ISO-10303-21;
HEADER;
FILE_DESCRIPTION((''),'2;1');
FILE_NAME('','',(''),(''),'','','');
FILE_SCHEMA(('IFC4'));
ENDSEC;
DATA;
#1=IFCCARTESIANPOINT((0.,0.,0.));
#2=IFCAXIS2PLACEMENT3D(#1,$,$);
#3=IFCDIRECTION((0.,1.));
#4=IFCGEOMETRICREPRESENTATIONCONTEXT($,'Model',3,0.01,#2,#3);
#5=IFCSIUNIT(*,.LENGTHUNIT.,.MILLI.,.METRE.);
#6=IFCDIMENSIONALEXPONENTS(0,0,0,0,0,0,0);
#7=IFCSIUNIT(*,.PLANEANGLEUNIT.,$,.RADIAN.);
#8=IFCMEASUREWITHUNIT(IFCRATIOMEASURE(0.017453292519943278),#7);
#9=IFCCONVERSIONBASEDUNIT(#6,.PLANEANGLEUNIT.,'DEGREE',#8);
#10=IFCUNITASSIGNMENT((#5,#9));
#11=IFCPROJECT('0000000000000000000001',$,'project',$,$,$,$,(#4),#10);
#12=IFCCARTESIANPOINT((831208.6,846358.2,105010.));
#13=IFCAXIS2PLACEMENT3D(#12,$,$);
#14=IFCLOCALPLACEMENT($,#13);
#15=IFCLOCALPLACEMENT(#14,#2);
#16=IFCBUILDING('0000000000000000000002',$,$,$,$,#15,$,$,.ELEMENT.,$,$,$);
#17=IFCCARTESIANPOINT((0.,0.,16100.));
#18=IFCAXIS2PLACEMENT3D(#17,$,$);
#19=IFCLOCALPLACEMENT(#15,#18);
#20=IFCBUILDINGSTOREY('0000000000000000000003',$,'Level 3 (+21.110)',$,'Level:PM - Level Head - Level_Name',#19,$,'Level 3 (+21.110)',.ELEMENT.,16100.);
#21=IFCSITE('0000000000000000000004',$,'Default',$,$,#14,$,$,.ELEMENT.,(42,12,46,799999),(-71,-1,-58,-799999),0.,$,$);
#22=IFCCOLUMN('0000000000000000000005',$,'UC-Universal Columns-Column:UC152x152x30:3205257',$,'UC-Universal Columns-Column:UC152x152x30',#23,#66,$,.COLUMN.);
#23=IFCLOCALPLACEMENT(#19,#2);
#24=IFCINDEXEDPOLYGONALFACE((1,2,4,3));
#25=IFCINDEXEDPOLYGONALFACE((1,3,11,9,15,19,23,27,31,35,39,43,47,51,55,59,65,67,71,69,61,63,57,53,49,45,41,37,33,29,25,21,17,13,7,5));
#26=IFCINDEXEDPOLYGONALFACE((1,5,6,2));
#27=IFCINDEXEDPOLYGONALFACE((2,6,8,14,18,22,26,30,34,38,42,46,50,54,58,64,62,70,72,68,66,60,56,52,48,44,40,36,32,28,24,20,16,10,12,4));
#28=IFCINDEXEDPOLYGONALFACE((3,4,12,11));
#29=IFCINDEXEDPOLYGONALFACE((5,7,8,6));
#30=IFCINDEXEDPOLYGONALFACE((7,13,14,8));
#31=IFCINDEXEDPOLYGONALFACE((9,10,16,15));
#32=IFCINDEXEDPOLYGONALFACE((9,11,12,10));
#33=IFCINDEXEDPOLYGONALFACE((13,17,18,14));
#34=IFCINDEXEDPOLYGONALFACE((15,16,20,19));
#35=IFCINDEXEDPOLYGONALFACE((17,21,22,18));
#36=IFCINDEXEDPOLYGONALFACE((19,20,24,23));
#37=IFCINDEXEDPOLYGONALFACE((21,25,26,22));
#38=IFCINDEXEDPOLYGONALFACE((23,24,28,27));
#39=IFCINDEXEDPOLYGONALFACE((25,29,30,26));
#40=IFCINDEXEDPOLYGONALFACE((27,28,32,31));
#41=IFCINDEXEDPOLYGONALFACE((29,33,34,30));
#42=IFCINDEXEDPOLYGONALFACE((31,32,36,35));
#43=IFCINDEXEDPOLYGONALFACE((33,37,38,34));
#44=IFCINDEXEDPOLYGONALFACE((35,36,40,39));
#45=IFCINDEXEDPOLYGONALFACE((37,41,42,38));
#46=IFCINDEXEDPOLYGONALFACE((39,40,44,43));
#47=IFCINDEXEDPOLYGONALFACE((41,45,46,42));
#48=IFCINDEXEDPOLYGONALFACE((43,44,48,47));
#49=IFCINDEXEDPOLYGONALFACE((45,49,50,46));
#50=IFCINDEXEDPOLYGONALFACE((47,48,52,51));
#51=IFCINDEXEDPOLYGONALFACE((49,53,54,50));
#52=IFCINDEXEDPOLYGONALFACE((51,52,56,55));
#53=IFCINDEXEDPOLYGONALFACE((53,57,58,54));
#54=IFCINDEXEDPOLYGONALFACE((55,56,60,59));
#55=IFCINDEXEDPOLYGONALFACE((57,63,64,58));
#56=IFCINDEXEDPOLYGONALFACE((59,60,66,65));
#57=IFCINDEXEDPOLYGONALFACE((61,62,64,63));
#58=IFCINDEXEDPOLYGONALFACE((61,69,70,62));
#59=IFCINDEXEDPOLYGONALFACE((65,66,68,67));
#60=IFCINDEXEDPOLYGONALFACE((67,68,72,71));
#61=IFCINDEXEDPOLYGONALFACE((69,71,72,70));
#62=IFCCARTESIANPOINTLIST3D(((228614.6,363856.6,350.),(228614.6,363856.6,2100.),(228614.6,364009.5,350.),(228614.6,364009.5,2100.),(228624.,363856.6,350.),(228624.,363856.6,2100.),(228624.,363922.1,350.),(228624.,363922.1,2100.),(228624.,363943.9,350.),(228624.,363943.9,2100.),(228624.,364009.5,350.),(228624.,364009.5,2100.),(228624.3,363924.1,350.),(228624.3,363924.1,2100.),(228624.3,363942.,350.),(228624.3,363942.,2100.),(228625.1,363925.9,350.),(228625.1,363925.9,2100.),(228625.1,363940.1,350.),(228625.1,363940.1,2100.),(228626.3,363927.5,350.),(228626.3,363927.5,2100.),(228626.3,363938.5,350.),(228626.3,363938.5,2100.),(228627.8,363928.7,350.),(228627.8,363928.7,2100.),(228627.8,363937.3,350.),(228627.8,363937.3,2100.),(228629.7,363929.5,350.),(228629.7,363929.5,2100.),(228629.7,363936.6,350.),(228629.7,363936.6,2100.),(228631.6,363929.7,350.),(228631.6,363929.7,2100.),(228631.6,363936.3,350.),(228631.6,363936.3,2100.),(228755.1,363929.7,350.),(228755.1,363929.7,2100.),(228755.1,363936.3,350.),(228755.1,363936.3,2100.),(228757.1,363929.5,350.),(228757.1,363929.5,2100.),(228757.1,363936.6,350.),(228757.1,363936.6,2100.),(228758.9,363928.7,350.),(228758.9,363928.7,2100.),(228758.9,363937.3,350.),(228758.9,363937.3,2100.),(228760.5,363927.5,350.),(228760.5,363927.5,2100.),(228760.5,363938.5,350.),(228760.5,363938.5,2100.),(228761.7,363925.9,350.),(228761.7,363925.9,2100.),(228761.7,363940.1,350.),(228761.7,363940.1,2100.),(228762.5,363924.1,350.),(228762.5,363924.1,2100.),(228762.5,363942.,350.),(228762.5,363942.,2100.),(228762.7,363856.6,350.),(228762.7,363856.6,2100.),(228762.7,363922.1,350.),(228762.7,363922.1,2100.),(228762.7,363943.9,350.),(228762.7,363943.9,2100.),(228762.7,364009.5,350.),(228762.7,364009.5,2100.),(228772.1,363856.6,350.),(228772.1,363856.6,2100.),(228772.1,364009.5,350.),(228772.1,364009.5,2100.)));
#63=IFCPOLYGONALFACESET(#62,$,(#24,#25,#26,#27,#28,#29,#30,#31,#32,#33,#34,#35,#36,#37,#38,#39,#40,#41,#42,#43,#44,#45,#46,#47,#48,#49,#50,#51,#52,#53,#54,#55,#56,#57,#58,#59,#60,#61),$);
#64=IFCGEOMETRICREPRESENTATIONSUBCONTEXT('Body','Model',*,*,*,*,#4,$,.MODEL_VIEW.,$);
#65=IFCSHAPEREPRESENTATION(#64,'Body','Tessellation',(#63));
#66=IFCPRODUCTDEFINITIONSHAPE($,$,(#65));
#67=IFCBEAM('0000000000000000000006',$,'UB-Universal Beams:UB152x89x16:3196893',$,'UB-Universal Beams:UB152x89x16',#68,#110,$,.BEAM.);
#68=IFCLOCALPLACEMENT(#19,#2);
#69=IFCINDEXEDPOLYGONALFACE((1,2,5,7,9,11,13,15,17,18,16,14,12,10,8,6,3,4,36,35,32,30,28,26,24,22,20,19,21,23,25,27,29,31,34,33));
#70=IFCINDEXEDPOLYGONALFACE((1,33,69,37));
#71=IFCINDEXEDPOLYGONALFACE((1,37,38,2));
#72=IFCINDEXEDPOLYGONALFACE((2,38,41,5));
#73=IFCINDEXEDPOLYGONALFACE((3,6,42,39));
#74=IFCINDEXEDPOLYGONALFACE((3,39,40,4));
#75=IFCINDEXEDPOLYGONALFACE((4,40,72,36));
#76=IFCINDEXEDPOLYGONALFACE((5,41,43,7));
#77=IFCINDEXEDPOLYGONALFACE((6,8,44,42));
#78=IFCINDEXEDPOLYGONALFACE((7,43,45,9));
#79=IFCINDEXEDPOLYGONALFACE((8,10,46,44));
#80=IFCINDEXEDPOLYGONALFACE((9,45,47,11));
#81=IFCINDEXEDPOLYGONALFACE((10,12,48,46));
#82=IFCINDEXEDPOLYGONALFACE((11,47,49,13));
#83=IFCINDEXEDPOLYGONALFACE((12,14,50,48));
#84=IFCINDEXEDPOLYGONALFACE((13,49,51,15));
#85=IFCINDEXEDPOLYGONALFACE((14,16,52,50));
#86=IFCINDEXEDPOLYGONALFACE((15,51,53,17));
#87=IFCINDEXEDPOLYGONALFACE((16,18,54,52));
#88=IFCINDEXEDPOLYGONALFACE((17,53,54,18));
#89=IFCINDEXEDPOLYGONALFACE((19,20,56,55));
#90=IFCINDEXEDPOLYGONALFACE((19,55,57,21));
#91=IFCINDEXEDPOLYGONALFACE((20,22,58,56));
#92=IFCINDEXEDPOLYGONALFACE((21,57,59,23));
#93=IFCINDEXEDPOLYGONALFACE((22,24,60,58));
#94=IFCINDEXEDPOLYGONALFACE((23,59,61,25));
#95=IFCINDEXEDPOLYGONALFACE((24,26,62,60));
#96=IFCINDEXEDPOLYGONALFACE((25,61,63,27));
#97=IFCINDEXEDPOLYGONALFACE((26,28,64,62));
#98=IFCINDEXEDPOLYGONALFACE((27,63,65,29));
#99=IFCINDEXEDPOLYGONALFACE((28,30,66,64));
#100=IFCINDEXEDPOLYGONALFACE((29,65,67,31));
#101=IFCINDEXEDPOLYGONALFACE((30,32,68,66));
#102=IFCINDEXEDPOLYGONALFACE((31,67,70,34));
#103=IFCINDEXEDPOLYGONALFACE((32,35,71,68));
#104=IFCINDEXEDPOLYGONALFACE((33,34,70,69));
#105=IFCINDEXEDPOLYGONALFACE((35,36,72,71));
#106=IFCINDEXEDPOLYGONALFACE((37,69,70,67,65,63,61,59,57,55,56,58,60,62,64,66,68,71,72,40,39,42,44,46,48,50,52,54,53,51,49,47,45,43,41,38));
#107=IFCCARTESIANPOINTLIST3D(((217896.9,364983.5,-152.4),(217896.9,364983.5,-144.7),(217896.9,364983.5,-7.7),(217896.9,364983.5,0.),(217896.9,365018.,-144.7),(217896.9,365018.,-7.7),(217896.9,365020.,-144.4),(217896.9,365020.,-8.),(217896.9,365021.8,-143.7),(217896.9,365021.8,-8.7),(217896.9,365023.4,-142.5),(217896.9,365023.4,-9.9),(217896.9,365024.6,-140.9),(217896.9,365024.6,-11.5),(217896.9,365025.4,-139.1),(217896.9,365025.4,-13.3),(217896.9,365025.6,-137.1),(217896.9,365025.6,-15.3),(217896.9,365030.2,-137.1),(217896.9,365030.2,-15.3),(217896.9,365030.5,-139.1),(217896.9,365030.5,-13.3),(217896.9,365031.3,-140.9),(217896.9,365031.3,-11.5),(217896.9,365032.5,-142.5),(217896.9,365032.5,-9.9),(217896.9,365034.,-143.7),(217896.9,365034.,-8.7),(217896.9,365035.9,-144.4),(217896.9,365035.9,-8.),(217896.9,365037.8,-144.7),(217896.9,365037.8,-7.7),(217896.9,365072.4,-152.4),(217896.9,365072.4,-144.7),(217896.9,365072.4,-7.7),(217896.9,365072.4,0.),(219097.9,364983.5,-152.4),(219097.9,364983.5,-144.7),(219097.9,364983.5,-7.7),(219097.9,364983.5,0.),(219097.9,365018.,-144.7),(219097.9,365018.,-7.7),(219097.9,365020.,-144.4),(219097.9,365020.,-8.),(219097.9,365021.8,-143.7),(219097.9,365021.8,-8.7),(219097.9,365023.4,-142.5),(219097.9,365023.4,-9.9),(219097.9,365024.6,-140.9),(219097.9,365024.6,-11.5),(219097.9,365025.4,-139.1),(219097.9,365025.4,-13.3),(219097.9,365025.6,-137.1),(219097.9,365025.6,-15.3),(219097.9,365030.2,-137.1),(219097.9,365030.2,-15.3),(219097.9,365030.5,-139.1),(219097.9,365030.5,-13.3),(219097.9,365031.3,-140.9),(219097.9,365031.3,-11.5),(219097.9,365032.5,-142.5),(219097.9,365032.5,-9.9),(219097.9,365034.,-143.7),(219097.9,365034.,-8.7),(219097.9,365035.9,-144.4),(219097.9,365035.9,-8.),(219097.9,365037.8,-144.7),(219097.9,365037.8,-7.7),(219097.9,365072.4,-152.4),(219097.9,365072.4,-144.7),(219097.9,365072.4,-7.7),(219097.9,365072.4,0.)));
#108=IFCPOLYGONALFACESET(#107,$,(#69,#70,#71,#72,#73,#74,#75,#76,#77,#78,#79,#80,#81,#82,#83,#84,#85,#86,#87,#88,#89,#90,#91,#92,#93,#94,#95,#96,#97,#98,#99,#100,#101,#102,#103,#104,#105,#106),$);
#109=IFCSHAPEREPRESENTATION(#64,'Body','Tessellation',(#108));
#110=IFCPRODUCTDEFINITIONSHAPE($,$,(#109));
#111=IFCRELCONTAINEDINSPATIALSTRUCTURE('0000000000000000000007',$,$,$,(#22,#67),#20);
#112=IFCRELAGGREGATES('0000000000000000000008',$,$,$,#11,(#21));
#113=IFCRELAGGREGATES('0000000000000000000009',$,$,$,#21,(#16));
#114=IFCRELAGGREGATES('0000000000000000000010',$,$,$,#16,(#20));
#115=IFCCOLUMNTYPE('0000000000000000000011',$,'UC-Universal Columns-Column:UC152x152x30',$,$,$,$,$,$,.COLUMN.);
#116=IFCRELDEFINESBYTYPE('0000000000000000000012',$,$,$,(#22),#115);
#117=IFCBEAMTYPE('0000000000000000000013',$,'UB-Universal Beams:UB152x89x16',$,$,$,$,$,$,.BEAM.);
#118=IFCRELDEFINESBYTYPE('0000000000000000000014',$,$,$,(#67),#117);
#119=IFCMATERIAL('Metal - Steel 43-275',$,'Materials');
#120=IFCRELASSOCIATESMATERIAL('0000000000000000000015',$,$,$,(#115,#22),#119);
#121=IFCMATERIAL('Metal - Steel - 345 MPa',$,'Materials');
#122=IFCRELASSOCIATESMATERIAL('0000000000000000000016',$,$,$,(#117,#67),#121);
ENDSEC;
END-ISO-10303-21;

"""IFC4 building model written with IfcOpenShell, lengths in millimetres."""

from ifc_helpers import new_model, entity, si_unit, converted_unit, direction, frame, origin, place, context, subcontext, project, spatial, line, arc, indexed_curve, outline, extrude, source, transform, mapped, material, type_object, type_shapes, element, save


model = new_model("IFC4")

# Units and contexts
model_context = context("Model", 3, precision=0.01, world=origin(), true_north=direction((0.0, 1.0)))
body_context = subcontext(model_context, "Body", "Model", "MODEL_VIEW")
ifc_project = project(units=[si_unit("LENGTHUNIT", "METRE", prefix="MILLI"), converted_unit("PLANEANGLEUNIT", "DEGREE", entity("IfcRatioMeasure", 0.017453292519943278), si_unit("PLANEANGLEUNIT", "RADIAN"), dimensions=[0, 0, 0, 0, 0, 0, 0])], contexts=[model_context])

# Site, building, storey
site_placement = place(None, frame((831208.6, 846358.2, 105010.0)))
site = spatial("IfcSite", under=ifc_project, at=site_placement, Name="Default", CompositionType="ELEMENT", RefLatitude=(42, 12, 46, 799999), RefLongitude=(-71, -1, -58, -799999), RefElevation=0.0)
building_placement = place(site_placement, origin())
building = spatial("IfcBuilding", under=site, at=building_placement, CompositionType="ELEMENT")
storey_placement = place(building_placement, frame((0.0, 0.0, 16100.0)))
storey = spatial("IfcBuildingStorey", under=building, at=storey_placement, Name="Level 3 (+21.110)", ObjectType="Level:PM - Level Head - Level_Name", LongName="Level 3 (+21.110)", CompositionType="ELEMENT", Elevation=16100.0)

# Column
ifc_material_1 = material(Name="Metal - Steel 43-275", Category="Materials")
column_type = type_object("IfcColumnType", Name="UC-Universal Columns-Column:UC152x152x30", PredefinedType="COLUMN", material=ifc_material_1)
shared_shape_1 = source(origin(), body_context, "Body", "SweptSolid", [
    extrude(outline(indexed_curve([(69.3, -76.4), (78.7, -76.4), (78.7, 76.4), (69.3, 76.4), (69.3, 10.9), (67.1, 5.5), (61.7, 3.3), (-61.7, 3.3), (-67.1, 5.5), (-69.3, 10.9), (-69.3, 76.4), (-78.7, 76.4), (-78.7, -76.4), (-69.3, -76.4), (-69.3, -10.9), (-67.1, -5.5), (-61.7, -3.3), (61.7, -3.3), (67.1, -5.5), (69.3, -10.9)], segments=[line(1, 2, 3, 4, 5), arc(5, 6, 7), line(7, 8), arc(8, 9, 10), line(10, 11, 12, 13, 14, 15), arc(15, 16, 17), line(17, 18), arc(18, 19, 20), line(20, 1)], self_intersect=False)), frame((0.0, 0.0, 16450.0), z_axis=(0.0, 0.0, 1.0), x_axis=(0.0, -1.0, 0.0)), (0.0, 0.0, 1.0), 1750.0),
])
type_shapes(column_type, [shared_shape_1])
column_placement = place(storey_placement, frame((228693.4, 363933.0, -16100.0), z_axis=(0.0, 0.0, 1.0), x_axis=(0.0, 1.0, 0.0)))
element("IfcColumn", 1, at=column_placement, inside=storey, type_object=column_type, material=ifc_material_1, Name="UC-Universal Columns-Column:UC152x152x30:3205257", ObjectType="UC-Universal Columns-Column:UC152x152x30", PredefinedType="COLUMN", context=body_context, shape_type="MappedRepresentation", body=[
    mapped(shared_shape_1, transform((0.0, 0.0, 0.0), scale=1.0)),
])

# Beam
ifc_material_2 = material(Name="Metal - Steel - 345 MPa", Category="Materials")
beam_type = type_object("IfcBeamType", Name="UB-Universal Beams:UB152x89x16", PredefinedType="BEAM", material=ifc_material_2)
shared_shape_2 = source(origin(), body_context, "Body", "SweptSolid", [
    extrude(outline(indexed_curve([(-76.2, -44.5), (-68.5, -44.5), (-68.5, -9.9), (-66.3, -4.5), (-60.9, -2.3), (60.9, -2.3), (66.3, -4.5), (68.5, -9.9), (68.5, -44.5), (76.2, -44.5), (76.2, 44.5), (68.5, 44.5), (68.5, 9.9), (66.3, 4.5), (60.9, 2.3), (-60.9, 2.3), (-66.3, 4.5), (-68.5, 9.9), (-68.5, 44.4), (-76.2, 44.4)], segments=[line(1, 2, 3), arc(3, 4, 5), line(5, 6), arc(6, 7, 8), line(8, 9, 10, 11, 12, 13), arc(13, 14, 15), line(15, 16), arc(16, 17, 18), line(18, 19, 20, 1)], self_intersect=False)), frame((-600.5, 0.0, 0.0), z_axis=(1.0, 0.0, 0.0), x_axis=(0.0, 0.0, -1.0)), (0.0, 0.0, 1.0), 1201.0),
])
type_shapes(beam_type, [shared_shape_2])
beam_placement = place(storey_placement, frame((218497.4, 365027.9, -76.2), z_axis=(0.0, 0.0, 1.0), x_axis=(-1.0, 0.0, 0.0)))
element("IfcBeam", 2, at=beam_placement, inside=storey, type_object=beam_type, material=ifc_material_2, Name="UB-Universal Beams:UB152x89x16:3196893", ObjectType="UB-Universal Beams:UB152x89x16", PredefinedType="BEAM", context=body_context, shape_type="MappedRepresentation", body=[
    mapped(shared_shape_2, transform((0.0, 0.0, 0.0), scale=1.0)),
])

save(model, "model.ifc")
